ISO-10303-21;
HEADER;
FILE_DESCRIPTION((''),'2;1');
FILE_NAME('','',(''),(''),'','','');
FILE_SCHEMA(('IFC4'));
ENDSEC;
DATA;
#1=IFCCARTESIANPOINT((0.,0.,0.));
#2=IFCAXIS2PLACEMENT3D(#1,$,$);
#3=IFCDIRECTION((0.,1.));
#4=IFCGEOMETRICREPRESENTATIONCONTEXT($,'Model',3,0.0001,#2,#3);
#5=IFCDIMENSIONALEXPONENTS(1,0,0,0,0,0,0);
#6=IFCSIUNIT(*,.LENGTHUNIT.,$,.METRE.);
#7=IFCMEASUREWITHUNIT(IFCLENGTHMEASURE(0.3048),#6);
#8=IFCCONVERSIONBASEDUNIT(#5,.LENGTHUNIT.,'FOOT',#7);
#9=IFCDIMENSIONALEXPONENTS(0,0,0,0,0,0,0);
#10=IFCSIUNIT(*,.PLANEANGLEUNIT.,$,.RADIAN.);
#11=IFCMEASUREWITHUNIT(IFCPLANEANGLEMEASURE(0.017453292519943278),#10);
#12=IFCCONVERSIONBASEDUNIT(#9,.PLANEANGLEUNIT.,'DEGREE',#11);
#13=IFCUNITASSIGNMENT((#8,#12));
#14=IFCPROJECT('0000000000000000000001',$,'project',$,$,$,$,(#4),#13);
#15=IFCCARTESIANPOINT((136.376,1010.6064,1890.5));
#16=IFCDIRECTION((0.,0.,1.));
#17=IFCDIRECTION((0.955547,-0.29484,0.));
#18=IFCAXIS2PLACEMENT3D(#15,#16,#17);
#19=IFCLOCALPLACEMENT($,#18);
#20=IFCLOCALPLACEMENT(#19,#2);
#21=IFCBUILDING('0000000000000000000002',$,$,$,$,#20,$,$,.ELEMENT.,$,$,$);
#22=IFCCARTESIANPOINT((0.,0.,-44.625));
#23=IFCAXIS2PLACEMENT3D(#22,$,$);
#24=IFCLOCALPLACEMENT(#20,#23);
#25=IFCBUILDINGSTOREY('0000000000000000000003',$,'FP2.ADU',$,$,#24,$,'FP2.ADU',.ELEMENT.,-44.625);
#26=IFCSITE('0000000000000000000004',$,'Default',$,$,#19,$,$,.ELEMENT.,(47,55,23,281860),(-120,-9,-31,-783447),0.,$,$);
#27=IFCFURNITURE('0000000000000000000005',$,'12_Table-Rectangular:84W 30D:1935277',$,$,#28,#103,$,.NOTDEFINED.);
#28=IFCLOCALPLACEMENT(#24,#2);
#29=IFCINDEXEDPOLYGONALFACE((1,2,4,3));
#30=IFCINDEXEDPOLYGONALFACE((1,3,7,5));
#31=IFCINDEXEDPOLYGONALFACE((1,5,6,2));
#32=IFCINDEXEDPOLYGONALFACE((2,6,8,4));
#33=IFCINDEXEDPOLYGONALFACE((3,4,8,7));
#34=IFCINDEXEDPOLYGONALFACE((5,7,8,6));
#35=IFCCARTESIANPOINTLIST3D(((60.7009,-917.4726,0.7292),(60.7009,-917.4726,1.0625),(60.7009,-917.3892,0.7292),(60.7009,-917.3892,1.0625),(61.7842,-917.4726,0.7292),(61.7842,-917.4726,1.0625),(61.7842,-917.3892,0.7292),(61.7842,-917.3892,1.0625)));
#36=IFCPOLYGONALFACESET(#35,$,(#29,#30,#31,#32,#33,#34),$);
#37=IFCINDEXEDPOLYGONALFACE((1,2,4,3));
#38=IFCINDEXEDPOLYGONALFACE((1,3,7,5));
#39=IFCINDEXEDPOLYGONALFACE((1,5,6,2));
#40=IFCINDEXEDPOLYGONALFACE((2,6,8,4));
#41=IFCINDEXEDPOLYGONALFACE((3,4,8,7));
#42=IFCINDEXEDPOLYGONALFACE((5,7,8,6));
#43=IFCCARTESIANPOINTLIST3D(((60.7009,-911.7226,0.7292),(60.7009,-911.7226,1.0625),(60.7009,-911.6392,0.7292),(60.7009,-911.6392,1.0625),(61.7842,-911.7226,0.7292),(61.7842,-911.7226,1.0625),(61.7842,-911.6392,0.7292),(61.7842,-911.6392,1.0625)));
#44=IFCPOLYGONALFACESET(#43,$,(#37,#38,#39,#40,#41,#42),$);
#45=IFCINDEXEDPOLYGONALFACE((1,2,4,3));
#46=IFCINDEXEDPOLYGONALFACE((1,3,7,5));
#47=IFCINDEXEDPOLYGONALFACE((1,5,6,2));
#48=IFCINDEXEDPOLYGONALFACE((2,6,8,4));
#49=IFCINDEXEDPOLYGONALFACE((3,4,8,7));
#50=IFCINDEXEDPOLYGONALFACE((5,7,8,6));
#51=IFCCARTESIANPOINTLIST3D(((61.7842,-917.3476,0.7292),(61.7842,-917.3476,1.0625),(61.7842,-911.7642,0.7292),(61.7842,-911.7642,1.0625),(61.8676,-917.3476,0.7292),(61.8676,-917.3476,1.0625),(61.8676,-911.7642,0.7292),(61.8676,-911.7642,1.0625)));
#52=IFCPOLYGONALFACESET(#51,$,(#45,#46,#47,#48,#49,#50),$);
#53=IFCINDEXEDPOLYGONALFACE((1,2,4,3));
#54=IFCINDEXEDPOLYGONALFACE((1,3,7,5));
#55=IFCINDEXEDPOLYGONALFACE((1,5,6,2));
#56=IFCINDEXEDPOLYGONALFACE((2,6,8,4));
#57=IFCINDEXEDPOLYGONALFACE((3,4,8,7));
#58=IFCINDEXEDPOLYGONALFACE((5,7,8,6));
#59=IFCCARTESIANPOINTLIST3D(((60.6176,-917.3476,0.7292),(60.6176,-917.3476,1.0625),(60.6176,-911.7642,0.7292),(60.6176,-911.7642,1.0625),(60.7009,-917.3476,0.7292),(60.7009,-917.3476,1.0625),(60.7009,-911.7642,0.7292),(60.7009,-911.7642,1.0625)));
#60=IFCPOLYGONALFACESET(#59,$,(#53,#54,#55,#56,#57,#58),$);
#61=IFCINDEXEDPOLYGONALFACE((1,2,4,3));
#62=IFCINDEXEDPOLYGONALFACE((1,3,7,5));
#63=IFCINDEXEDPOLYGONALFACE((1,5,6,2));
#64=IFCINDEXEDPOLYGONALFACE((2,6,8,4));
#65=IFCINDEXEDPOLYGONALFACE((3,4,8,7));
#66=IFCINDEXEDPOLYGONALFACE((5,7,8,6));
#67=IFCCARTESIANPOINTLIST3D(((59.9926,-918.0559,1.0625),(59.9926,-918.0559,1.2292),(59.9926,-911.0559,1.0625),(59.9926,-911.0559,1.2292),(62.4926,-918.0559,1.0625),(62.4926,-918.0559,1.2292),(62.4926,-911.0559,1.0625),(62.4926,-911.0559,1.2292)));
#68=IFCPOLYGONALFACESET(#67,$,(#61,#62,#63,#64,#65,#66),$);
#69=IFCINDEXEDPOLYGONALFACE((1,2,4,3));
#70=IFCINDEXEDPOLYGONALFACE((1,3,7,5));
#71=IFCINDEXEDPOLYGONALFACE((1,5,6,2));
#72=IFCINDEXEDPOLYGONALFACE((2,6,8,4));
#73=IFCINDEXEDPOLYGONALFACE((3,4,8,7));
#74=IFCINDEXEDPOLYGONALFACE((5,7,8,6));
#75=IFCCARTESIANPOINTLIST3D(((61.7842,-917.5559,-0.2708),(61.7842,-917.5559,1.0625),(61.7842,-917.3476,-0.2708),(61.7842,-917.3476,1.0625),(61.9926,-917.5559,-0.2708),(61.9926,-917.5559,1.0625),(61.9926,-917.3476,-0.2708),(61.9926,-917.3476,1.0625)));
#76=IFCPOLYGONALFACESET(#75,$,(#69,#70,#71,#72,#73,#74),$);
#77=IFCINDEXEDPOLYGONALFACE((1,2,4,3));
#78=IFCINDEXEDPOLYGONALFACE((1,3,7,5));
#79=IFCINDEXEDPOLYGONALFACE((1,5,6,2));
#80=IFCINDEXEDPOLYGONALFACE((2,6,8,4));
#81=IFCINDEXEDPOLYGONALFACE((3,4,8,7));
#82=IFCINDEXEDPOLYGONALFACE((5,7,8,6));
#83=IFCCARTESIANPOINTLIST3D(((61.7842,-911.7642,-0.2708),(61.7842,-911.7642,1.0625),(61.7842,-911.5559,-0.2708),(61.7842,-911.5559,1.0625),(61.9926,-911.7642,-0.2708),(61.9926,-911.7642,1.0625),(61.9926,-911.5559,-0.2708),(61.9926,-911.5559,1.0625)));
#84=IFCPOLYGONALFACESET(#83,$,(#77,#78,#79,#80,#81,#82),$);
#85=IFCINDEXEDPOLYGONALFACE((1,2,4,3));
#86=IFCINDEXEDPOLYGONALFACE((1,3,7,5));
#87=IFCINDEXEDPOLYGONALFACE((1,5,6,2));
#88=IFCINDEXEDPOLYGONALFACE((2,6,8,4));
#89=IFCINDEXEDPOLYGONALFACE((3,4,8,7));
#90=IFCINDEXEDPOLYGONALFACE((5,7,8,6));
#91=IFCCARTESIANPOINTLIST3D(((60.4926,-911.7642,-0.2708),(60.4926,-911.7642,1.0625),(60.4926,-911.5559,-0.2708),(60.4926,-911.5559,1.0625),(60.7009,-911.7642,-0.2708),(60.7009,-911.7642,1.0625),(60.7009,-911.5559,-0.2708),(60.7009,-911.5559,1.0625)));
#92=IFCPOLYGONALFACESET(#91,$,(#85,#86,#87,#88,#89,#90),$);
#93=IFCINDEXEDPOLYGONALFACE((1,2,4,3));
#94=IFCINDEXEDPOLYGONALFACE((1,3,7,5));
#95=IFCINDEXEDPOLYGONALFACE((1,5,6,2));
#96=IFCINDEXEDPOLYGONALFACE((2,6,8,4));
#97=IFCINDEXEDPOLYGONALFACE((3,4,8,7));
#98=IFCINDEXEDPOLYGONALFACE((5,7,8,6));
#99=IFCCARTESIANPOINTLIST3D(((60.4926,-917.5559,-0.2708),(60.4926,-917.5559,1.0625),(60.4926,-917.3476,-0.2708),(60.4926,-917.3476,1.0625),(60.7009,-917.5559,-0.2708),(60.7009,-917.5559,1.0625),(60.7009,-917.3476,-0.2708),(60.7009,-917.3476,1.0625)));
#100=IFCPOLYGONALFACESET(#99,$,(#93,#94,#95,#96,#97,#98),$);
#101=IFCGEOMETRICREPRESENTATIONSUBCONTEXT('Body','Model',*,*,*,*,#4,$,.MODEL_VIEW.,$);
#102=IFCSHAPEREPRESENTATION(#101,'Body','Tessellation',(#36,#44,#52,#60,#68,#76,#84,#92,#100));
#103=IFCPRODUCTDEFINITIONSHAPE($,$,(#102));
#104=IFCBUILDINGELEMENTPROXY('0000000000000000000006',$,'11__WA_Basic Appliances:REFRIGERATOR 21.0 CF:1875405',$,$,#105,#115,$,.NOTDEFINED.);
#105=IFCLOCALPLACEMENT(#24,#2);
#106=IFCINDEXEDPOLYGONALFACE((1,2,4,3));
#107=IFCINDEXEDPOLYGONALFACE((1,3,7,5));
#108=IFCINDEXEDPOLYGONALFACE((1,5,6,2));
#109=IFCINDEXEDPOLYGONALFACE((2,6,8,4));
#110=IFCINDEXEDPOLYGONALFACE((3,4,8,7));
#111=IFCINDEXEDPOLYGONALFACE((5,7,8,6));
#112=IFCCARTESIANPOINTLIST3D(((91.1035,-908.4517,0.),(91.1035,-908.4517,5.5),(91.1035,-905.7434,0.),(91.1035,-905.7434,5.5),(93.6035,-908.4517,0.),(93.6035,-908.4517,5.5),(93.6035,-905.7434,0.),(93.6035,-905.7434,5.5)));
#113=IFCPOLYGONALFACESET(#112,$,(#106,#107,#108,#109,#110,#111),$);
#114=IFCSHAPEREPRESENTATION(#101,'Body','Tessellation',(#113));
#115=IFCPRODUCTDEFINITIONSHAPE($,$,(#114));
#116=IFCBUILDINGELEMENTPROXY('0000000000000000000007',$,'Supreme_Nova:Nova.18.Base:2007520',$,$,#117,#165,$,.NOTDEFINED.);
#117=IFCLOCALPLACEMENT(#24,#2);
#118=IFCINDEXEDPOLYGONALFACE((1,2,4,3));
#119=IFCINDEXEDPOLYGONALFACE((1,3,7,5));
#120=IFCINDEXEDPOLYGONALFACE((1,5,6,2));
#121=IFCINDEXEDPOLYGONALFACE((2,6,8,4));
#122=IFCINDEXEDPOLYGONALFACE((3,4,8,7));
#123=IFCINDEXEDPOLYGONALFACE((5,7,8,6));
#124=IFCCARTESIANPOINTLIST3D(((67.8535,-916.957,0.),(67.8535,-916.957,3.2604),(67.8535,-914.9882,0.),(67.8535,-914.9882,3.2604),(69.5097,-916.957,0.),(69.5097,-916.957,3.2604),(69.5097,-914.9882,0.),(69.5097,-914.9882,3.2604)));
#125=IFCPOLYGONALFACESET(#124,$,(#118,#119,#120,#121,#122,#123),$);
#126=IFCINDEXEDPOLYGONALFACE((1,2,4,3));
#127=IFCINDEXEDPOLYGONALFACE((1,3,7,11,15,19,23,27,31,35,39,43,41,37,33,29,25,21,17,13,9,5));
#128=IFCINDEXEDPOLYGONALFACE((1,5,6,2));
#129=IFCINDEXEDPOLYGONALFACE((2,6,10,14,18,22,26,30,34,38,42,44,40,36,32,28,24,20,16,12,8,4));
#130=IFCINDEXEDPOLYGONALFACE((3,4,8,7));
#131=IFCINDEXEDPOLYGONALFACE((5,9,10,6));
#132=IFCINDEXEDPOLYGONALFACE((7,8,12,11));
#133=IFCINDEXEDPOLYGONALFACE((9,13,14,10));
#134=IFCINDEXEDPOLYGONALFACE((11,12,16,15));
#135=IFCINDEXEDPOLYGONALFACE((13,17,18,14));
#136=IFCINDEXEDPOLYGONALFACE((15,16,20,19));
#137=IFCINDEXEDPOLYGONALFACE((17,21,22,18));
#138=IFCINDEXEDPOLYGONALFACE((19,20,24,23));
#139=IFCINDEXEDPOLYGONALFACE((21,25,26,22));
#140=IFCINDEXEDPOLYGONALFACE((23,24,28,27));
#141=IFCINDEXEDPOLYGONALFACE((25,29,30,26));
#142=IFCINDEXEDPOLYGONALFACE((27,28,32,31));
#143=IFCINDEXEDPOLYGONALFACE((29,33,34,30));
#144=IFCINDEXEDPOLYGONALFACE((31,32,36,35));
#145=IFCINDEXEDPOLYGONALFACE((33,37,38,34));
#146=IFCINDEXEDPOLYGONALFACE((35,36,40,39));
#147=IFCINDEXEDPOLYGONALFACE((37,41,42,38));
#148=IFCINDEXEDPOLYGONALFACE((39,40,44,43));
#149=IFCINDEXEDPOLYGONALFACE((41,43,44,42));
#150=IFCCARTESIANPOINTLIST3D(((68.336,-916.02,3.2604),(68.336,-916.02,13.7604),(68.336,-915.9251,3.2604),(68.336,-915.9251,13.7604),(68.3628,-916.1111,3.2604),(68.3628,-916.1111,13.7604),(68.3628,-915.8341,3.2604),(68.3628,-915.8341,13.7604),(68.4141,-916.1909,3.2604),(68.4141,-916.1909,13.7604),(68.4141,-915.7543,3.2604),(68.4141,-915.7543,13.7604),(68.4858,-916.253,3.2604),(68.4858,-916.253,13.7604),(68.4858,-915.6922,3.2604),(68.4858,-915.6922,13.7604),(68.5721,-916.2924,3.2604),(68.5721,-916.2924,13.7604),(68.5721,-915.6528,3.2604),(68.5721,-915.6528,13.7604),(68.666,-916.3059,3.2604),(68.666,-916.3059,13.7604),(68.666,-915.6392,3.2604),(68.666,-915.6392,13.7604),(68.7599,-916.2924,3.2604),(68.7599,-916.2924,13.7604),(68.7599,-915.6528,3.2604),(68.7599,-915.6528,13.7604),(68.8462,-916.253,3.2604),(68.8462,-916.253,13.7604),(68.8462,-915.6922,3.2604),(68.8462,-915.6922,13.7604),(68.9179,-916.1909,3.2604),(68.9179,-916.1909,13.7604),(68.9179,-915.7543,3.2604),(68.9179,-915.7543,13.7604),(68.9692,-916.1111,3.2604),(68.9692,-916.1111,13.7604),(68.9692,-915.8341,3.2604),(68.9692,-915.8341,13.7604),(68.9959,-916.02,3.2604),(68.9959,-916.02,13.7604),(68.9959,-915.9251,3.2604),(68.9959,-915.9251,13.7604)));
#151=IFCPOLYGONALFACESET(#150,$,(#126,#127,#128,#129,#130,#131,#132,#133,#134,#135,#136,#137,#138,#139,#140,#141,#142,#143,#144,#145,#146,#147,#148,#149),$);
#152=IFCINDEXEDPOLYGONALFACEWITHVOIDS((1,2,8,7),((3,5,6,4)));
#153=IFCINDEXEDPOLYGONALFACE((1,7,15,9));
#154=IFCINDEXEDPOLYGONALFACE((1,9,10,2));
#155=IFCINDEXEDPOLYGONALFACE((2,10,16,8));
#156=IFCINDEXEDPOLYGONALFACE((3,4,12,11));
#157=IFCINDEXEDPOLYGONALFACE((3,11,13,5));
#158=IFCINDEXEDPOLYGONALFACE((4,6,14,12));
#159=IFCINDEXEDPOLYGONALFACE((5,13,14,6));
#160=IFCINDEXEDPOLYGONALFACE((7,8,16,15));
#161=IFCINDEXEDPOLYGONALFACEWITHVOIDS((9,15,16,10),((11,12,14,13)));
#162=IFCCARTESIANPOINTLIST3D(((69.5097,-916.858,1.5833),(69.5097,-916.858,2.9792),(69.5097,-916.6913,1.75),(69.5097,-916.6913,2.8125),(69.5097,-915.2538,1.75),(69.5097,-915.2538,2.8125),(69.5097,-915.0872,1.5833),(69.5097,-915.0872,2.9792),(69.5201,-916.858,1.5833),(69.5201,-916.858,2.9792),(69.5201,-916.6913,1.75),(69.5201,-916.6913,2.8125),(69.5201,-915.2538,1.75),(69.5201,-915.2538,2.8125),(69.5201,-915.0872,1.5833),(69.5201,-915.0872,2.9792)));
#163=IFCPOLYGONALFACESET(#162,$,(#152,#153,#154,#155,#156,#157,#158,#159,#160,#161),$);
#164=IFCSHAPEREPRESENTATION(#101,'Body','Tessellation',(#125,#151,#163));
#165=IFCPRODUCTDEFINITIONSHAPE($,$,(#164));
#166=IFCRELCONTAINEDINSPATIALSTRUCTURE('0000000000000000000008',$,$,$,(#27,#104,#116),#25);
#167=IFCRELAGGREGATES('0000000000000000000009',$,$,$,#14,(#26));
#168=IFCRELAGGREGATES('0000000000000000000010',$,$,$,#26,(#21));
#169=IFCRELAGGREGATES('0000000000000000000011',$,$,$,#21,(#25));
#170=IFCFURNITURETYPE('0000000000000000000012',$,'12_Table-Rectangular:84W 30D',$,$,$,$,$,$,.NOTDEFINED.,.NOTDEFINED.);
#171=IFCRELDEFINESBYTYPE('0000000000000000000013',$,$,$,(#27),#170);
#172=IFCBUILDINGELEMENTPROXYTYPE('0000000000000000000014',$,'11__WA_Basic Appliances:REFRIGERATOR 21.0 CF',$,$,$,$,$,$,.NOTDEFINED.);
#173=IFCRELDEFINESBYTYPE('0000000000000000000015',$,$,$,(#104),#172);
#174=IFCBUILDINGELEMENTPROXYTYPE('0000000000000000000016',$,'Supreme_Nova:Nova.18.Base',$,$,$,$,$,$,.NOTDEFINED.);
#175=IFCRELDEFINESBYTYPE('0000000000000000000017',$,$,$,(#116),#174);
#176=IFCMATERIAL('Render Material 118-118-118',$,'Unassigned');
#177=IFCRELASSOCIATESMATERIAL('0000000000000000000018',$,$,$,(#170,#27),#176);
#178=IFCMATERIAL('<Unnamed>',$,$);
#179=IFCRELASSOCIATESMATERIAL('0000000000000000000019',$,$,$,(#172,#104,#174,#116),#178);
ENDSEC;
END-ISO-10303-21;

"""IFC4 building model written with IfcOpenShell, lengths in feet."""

from ifc_helpers import new_model, entity, si_unit, converted_unit, direction, frame, origin, place, context, subcontext, project, spatial, arc, indexed_curve, outline, extrude, source, transform, mapped, material, type_object, type_shapes, element, save


model = new_model("IFC4")

# Units and contexts
model_context = context("Model", 3, precision=0.0001, world=origin(), true_north=direction((0.0, 1.0)))
body_context = subcontext(model_context, "Body", "Model", "MODEL_VIEW")
ifc_project = project(units=[converted_unit("LENGTHUNIT", "FOOT", entity("IfcLengthMeasure", 0.3048), si_unit("LENGTHUNIT", "METRE"), dimensions=[1, 0, 0, 0, 0, 0, 0]), converted_unit("PLANEANGLEUNIT", "DEGREE", entity("IfcPlaneAngleMeasure", 0.017453292519943278), si_unit("PLANEANGLEUNIT", "RADIAN"), dimensions=[0, 0, 0, 0, 0, 0, 0])], contexts=[model_context])

# Site, building, storey
site_placement = place(None, frame((136.376, 1010.6064, 1890.5), z_axis=(0.0, 0.0, 1.0), x_axis=(0.955547, -0.29484, 0.0)))
site = spatial("IfcSite", under=ifc_project, at=site_placement, Name="Default", CompositionType="ELEMENT", RefLatitude=(47, 55, 23, 281860), RefLongitude=(-120, -9, -31, -783447), RefElevation=0.0)
building_placement = place(site_placement, origin())
building = spatial("IfcBuilding", under=site, at=building_placement, CompositionType="ELEMENT")
storey_placement = place(building_placement, frame((0.0, 0.0, -44.625)))
storey = spatial("IfcBuildingStorey", under=building, at=storey_placement, Name="FP2.ADU", LongName="FP2.ADU", CompositionType="ELEMENT", Elevation=-44.625)

# Furniture
ifc_material_1 = material(Name="Render Material 118-118-118", Category="Unassigned")
ifc_material_2 = material(Name="<Unnamed>")
furniture_type_1 = type_object("IfcFurnitureType", Name="12_Table-Rectangular:84W 30D", AssemblyPlace="NOTDEFINED", PredefinedType="NOTDEFINED", material=ifc_material_1)
shared_shape_1 = source(origin(), body_context, "Body", "SweptSolid", [
    extrude(outline(indexed_curve([(-0.0417, -0.5417), (0.0417, -0.5417), (0.0417, 0.5417), (-0.0417, 0.5417), (-0.0417, -0.5417)], self_intersect=False)), frame((2.875, 0.0, 1.0)), (0.0, 0.0, 1.0), 0.3333),
    extrude(outline(indexed_curve([(-0.5417, -0.0417), (0.5417, -0.0417), (0.5417, 0.0417), (-0.5417, 0.0417), (-0.5417, -0.0417)], self_intersect=False)), frame((-2.875, 0.0, 1.0), z_axis=(0.0, 0.0, 1.0), x_axis=(0.0, 1.0, 0.0)), (0.0, 0.0, 1.0), 0.3333),
    extrude(outline(indexed_curve([(-2.7917, -0.0417), (2.7917, -0.0417), (2.7917, 0.0417), (-2.7917, 0.0417), (-2.7917, -0.0417)], self_intersect=False)), frame((0.0, 0.5833, 1.0), z_axis=(0.0, 0.0, 1.0), x_axis=(-1.0, 0.0, 0.0)), (0.0, 0.0, 1.0), 0.3333),
    extrude(outline(indexed_curve([(-0.0417, -2.7917), (0.0417, -2.7917), (0.0417, 2.7917), (-0.0417, 2.7917), (-0.0417, -2.7917)], self_intersect=False)), frame((0.0, -0.5833, 1.0), z_axis=(0.0, 0.0, 1.0), x_axis=(0.0, 1.0, 0.0)), (0.0, 0.0, 1.0), 0.3333),
    extrude(outline(indexed_curve([(-3.5, -1.25), (3.5, -1.25), (3.5, 1.25), (-3.5, 1.25), (-3.5, -1.25)], self_intersect=False)), frame((0.0, 0.0, 1.3333), z_axis=(0.0, 0.0, 1.0), x_axis=(-1.0, 0.0, 0.0)), (0.0, 0.0, 1.0), 0.1667),
    extrude(outline(indexed_curve([(-0.1042, -0.1042), (0.1042, -0.1042), (0.1042, 0.1042), (-0.1042, 0.1042), (-0.1042, -0.1042)], self_intersect=False)), frame((2.8958, 0.6458, 0.0), z_axis=(0.0, 0.0, 1.0), x_axis=(0.0, -1.0, 0.0)), (0.0, 0.0, 1.0), 1.3333),
    extrude(outline(indexed_curve([(-0.1042, -0.1042), (0.1042, -0.1042), (0.1042, 0.1042), (-0.1042, 0.1042), (-0.1042, -0.1042)], self_intersect=False)), frame((-2.8958, 0.6458, 0.0), z_axis=(0.0, 0.0, 1.0), x_axis=(-1.0, 0.0, 0.0)), (0.0, 0.0, 1.0), 1.3333),
    extrude(outline(indexed_curve([(-0.1042, -0.1042), (0.1042, -0.1042), (0.1042, 0.1042), (-0.1042, 0.1042), (-0.1042, -0.1042)], self_intersect=False)), frame((-2.8958, -0.6458, 0.0), z_axis=(0.0, 0.0, 1.0), x_axis=(0.0, 1.0, 0.0)), (0.0, 0.0, 1.0), 1.3333),
    extrude(outline(indexed_curve([(-0.1042, -0.1042), (0.1042, -0.1042), (0.1042, 0.1042), (-0.1042, 0.1042), (-0.1042, -0.1042)], self_intersect=False)), frame((2.8958, -0.6458, 0.0)), (0.0, 0.0, 1.0), 1.3333),
])
type_shapes(furniture_type_1, [shared_shape_1])
furniture_1_placement = place(storey_placement, frame((61.2426, -914.5559, -0.2708), z_axis=(0.0, 0.0, 1.0), x_axis=(0.0, -1.0, 0.0)))
element("IfcFurniture", 1, at=furniture_1_placement, inside=storey, type_object=furniture_type_1, material=ifc_material_1, Name="12_Table-Rectangular:84W 30D:1935277", PredefinedType="NOTDEFINED", context=body_context, shape_type="MappedRepresentation", body=[
    mapped(shared_shape_1, transform((0.0, 0.0, 0.0), scale=1.0)),
])

# Building element proxies
building_element_proxy_type_1 = type_object("IfcBuildingElementProxyType", Name="11__WA_Basic Appliances:REFRIGERATOR 21.0 CF", PredefinedType="NOTDEFINED", material=ifc_material_2)
shared_shape_2 = source(origin(), body_context, "Body", "SweptSolid", [
    extrude(outline(indexed_curve([(-1.3542, -1.25), (1.3542, -1.25), (1.3542, 1.25), (-1.3542, 1.25), (-1.3542, -1.25)], self_intersect=False)), frame((0.0, 0.0, 0.0), z_axis=(0.0, 0.0, 1.0), x_axis=(-1.0, 0.0, 0.0)), (0.0, 0.0, 1.0), 5.5),
])
type_shapes(building_element_proxy_type_1, [shared_shape_2])
proxy_1_placement = place(storey_placement, frame((92.3535, -907.0976, 0.0), z_axis=(0.0, 0.0, 1.0), x_axis=(0.0, -1.0, 0.0)))
element("IfcBuildingElementProxy", 2, at=proxy_1_placement, inside=storey, type_object=building_element_proxy_type_1, material=ifc_material_2, Name="11__WA_Basic Appliances:REFRIGERATOR 21.0 CF:1875405", PredefinedType="NOTDEFINED", context=body_context, shape_type="MappedRepresentation", body=[
    mapped(shared_shape_2, transform((0.0, 0.0, 0.0), scale=1.0)),
])
building_element_proxy_type_2 = type_object("IfcBuildingElementProxyType", Name="Supreme_Nova:Nova.18.Base", PredefinedType="NOTDEFINED", material=ifc_material_2)
shared_shape_3 = source(origin(), body_context, "Body", "SweptSolid", [
    extrude(outline(indexed_curve([(-0.9844, -0.8281), (0.9844, -0.8281), (0.9844, 0.8281), (-0.9844, 0.8281), (-0.9844, -0.8281)], self_intersect=False)), frame((0.0, -0.0156, 0.0), z_axis=(0.0, 0.0, 1.0), x_axis=(-1.0, 0.0, 0.0)), (0.0, 0.0, 1.0), 3.2604),
    extrude(outline(indexed_curve([(-0.3333, 0.0), (0.0, -0.3333), (0.3333, 0.0), (0.0, 0.3333)], segments=[arc(1, 2, 3), arc(3, 4, 1)], self_intersect=False)), frame((0.0, 0.0, 3.2604)), (0.0, 0.0, 1.0), 10.5),
    extrude(outline(indexed_curve([(-0.6979, -0.8854), (0.6979, -0.8854), (0.6979, 0.8854), (-0.6979, 0.8854), (-0.6979, -0.8854)], self_intersect=False), holes=[indexed_curve([(-0.5312, -0.7187), (-0.5312, 0.7188), (0.5312, 0.7188), (0.5312, -0.7187), (-0.5312, -0.7187)], self_intersect=False)]), frame((0.0, -0.8542, 2.2813), z_axis=(0.0, 1.0, 0.0), x_axis=(0.0, 0.0, -1.0)), (0.0, 0.0, 1.0), 0.0104),
])
type_shapes(building_element_proxy_type_2, [shared_shape_3])
proxy_2_placement = place(storey_placement, frame((68.666, -915.9726, 0.0), z_axis=(0.0, 0.0, 1.0), x_axis=(0.0, 1.0, 0.0)))
element("IfcBuildingElementProxy", 3, at=proxy_2_placement, inside=storey, type_object=building_element_proxy_type_2, material=ifc_material_2, Name="Supreme_Nova:Nova.18.Base:2007520", PredefinedType="NOTDEFINED", context=body_context, shape_type="MappedRepresentation", body=[
    mapped(shared_shape_3, transform((0.0, 0.0, 0.0), scale=1.0)),
])

save(model, "model.ifc")
